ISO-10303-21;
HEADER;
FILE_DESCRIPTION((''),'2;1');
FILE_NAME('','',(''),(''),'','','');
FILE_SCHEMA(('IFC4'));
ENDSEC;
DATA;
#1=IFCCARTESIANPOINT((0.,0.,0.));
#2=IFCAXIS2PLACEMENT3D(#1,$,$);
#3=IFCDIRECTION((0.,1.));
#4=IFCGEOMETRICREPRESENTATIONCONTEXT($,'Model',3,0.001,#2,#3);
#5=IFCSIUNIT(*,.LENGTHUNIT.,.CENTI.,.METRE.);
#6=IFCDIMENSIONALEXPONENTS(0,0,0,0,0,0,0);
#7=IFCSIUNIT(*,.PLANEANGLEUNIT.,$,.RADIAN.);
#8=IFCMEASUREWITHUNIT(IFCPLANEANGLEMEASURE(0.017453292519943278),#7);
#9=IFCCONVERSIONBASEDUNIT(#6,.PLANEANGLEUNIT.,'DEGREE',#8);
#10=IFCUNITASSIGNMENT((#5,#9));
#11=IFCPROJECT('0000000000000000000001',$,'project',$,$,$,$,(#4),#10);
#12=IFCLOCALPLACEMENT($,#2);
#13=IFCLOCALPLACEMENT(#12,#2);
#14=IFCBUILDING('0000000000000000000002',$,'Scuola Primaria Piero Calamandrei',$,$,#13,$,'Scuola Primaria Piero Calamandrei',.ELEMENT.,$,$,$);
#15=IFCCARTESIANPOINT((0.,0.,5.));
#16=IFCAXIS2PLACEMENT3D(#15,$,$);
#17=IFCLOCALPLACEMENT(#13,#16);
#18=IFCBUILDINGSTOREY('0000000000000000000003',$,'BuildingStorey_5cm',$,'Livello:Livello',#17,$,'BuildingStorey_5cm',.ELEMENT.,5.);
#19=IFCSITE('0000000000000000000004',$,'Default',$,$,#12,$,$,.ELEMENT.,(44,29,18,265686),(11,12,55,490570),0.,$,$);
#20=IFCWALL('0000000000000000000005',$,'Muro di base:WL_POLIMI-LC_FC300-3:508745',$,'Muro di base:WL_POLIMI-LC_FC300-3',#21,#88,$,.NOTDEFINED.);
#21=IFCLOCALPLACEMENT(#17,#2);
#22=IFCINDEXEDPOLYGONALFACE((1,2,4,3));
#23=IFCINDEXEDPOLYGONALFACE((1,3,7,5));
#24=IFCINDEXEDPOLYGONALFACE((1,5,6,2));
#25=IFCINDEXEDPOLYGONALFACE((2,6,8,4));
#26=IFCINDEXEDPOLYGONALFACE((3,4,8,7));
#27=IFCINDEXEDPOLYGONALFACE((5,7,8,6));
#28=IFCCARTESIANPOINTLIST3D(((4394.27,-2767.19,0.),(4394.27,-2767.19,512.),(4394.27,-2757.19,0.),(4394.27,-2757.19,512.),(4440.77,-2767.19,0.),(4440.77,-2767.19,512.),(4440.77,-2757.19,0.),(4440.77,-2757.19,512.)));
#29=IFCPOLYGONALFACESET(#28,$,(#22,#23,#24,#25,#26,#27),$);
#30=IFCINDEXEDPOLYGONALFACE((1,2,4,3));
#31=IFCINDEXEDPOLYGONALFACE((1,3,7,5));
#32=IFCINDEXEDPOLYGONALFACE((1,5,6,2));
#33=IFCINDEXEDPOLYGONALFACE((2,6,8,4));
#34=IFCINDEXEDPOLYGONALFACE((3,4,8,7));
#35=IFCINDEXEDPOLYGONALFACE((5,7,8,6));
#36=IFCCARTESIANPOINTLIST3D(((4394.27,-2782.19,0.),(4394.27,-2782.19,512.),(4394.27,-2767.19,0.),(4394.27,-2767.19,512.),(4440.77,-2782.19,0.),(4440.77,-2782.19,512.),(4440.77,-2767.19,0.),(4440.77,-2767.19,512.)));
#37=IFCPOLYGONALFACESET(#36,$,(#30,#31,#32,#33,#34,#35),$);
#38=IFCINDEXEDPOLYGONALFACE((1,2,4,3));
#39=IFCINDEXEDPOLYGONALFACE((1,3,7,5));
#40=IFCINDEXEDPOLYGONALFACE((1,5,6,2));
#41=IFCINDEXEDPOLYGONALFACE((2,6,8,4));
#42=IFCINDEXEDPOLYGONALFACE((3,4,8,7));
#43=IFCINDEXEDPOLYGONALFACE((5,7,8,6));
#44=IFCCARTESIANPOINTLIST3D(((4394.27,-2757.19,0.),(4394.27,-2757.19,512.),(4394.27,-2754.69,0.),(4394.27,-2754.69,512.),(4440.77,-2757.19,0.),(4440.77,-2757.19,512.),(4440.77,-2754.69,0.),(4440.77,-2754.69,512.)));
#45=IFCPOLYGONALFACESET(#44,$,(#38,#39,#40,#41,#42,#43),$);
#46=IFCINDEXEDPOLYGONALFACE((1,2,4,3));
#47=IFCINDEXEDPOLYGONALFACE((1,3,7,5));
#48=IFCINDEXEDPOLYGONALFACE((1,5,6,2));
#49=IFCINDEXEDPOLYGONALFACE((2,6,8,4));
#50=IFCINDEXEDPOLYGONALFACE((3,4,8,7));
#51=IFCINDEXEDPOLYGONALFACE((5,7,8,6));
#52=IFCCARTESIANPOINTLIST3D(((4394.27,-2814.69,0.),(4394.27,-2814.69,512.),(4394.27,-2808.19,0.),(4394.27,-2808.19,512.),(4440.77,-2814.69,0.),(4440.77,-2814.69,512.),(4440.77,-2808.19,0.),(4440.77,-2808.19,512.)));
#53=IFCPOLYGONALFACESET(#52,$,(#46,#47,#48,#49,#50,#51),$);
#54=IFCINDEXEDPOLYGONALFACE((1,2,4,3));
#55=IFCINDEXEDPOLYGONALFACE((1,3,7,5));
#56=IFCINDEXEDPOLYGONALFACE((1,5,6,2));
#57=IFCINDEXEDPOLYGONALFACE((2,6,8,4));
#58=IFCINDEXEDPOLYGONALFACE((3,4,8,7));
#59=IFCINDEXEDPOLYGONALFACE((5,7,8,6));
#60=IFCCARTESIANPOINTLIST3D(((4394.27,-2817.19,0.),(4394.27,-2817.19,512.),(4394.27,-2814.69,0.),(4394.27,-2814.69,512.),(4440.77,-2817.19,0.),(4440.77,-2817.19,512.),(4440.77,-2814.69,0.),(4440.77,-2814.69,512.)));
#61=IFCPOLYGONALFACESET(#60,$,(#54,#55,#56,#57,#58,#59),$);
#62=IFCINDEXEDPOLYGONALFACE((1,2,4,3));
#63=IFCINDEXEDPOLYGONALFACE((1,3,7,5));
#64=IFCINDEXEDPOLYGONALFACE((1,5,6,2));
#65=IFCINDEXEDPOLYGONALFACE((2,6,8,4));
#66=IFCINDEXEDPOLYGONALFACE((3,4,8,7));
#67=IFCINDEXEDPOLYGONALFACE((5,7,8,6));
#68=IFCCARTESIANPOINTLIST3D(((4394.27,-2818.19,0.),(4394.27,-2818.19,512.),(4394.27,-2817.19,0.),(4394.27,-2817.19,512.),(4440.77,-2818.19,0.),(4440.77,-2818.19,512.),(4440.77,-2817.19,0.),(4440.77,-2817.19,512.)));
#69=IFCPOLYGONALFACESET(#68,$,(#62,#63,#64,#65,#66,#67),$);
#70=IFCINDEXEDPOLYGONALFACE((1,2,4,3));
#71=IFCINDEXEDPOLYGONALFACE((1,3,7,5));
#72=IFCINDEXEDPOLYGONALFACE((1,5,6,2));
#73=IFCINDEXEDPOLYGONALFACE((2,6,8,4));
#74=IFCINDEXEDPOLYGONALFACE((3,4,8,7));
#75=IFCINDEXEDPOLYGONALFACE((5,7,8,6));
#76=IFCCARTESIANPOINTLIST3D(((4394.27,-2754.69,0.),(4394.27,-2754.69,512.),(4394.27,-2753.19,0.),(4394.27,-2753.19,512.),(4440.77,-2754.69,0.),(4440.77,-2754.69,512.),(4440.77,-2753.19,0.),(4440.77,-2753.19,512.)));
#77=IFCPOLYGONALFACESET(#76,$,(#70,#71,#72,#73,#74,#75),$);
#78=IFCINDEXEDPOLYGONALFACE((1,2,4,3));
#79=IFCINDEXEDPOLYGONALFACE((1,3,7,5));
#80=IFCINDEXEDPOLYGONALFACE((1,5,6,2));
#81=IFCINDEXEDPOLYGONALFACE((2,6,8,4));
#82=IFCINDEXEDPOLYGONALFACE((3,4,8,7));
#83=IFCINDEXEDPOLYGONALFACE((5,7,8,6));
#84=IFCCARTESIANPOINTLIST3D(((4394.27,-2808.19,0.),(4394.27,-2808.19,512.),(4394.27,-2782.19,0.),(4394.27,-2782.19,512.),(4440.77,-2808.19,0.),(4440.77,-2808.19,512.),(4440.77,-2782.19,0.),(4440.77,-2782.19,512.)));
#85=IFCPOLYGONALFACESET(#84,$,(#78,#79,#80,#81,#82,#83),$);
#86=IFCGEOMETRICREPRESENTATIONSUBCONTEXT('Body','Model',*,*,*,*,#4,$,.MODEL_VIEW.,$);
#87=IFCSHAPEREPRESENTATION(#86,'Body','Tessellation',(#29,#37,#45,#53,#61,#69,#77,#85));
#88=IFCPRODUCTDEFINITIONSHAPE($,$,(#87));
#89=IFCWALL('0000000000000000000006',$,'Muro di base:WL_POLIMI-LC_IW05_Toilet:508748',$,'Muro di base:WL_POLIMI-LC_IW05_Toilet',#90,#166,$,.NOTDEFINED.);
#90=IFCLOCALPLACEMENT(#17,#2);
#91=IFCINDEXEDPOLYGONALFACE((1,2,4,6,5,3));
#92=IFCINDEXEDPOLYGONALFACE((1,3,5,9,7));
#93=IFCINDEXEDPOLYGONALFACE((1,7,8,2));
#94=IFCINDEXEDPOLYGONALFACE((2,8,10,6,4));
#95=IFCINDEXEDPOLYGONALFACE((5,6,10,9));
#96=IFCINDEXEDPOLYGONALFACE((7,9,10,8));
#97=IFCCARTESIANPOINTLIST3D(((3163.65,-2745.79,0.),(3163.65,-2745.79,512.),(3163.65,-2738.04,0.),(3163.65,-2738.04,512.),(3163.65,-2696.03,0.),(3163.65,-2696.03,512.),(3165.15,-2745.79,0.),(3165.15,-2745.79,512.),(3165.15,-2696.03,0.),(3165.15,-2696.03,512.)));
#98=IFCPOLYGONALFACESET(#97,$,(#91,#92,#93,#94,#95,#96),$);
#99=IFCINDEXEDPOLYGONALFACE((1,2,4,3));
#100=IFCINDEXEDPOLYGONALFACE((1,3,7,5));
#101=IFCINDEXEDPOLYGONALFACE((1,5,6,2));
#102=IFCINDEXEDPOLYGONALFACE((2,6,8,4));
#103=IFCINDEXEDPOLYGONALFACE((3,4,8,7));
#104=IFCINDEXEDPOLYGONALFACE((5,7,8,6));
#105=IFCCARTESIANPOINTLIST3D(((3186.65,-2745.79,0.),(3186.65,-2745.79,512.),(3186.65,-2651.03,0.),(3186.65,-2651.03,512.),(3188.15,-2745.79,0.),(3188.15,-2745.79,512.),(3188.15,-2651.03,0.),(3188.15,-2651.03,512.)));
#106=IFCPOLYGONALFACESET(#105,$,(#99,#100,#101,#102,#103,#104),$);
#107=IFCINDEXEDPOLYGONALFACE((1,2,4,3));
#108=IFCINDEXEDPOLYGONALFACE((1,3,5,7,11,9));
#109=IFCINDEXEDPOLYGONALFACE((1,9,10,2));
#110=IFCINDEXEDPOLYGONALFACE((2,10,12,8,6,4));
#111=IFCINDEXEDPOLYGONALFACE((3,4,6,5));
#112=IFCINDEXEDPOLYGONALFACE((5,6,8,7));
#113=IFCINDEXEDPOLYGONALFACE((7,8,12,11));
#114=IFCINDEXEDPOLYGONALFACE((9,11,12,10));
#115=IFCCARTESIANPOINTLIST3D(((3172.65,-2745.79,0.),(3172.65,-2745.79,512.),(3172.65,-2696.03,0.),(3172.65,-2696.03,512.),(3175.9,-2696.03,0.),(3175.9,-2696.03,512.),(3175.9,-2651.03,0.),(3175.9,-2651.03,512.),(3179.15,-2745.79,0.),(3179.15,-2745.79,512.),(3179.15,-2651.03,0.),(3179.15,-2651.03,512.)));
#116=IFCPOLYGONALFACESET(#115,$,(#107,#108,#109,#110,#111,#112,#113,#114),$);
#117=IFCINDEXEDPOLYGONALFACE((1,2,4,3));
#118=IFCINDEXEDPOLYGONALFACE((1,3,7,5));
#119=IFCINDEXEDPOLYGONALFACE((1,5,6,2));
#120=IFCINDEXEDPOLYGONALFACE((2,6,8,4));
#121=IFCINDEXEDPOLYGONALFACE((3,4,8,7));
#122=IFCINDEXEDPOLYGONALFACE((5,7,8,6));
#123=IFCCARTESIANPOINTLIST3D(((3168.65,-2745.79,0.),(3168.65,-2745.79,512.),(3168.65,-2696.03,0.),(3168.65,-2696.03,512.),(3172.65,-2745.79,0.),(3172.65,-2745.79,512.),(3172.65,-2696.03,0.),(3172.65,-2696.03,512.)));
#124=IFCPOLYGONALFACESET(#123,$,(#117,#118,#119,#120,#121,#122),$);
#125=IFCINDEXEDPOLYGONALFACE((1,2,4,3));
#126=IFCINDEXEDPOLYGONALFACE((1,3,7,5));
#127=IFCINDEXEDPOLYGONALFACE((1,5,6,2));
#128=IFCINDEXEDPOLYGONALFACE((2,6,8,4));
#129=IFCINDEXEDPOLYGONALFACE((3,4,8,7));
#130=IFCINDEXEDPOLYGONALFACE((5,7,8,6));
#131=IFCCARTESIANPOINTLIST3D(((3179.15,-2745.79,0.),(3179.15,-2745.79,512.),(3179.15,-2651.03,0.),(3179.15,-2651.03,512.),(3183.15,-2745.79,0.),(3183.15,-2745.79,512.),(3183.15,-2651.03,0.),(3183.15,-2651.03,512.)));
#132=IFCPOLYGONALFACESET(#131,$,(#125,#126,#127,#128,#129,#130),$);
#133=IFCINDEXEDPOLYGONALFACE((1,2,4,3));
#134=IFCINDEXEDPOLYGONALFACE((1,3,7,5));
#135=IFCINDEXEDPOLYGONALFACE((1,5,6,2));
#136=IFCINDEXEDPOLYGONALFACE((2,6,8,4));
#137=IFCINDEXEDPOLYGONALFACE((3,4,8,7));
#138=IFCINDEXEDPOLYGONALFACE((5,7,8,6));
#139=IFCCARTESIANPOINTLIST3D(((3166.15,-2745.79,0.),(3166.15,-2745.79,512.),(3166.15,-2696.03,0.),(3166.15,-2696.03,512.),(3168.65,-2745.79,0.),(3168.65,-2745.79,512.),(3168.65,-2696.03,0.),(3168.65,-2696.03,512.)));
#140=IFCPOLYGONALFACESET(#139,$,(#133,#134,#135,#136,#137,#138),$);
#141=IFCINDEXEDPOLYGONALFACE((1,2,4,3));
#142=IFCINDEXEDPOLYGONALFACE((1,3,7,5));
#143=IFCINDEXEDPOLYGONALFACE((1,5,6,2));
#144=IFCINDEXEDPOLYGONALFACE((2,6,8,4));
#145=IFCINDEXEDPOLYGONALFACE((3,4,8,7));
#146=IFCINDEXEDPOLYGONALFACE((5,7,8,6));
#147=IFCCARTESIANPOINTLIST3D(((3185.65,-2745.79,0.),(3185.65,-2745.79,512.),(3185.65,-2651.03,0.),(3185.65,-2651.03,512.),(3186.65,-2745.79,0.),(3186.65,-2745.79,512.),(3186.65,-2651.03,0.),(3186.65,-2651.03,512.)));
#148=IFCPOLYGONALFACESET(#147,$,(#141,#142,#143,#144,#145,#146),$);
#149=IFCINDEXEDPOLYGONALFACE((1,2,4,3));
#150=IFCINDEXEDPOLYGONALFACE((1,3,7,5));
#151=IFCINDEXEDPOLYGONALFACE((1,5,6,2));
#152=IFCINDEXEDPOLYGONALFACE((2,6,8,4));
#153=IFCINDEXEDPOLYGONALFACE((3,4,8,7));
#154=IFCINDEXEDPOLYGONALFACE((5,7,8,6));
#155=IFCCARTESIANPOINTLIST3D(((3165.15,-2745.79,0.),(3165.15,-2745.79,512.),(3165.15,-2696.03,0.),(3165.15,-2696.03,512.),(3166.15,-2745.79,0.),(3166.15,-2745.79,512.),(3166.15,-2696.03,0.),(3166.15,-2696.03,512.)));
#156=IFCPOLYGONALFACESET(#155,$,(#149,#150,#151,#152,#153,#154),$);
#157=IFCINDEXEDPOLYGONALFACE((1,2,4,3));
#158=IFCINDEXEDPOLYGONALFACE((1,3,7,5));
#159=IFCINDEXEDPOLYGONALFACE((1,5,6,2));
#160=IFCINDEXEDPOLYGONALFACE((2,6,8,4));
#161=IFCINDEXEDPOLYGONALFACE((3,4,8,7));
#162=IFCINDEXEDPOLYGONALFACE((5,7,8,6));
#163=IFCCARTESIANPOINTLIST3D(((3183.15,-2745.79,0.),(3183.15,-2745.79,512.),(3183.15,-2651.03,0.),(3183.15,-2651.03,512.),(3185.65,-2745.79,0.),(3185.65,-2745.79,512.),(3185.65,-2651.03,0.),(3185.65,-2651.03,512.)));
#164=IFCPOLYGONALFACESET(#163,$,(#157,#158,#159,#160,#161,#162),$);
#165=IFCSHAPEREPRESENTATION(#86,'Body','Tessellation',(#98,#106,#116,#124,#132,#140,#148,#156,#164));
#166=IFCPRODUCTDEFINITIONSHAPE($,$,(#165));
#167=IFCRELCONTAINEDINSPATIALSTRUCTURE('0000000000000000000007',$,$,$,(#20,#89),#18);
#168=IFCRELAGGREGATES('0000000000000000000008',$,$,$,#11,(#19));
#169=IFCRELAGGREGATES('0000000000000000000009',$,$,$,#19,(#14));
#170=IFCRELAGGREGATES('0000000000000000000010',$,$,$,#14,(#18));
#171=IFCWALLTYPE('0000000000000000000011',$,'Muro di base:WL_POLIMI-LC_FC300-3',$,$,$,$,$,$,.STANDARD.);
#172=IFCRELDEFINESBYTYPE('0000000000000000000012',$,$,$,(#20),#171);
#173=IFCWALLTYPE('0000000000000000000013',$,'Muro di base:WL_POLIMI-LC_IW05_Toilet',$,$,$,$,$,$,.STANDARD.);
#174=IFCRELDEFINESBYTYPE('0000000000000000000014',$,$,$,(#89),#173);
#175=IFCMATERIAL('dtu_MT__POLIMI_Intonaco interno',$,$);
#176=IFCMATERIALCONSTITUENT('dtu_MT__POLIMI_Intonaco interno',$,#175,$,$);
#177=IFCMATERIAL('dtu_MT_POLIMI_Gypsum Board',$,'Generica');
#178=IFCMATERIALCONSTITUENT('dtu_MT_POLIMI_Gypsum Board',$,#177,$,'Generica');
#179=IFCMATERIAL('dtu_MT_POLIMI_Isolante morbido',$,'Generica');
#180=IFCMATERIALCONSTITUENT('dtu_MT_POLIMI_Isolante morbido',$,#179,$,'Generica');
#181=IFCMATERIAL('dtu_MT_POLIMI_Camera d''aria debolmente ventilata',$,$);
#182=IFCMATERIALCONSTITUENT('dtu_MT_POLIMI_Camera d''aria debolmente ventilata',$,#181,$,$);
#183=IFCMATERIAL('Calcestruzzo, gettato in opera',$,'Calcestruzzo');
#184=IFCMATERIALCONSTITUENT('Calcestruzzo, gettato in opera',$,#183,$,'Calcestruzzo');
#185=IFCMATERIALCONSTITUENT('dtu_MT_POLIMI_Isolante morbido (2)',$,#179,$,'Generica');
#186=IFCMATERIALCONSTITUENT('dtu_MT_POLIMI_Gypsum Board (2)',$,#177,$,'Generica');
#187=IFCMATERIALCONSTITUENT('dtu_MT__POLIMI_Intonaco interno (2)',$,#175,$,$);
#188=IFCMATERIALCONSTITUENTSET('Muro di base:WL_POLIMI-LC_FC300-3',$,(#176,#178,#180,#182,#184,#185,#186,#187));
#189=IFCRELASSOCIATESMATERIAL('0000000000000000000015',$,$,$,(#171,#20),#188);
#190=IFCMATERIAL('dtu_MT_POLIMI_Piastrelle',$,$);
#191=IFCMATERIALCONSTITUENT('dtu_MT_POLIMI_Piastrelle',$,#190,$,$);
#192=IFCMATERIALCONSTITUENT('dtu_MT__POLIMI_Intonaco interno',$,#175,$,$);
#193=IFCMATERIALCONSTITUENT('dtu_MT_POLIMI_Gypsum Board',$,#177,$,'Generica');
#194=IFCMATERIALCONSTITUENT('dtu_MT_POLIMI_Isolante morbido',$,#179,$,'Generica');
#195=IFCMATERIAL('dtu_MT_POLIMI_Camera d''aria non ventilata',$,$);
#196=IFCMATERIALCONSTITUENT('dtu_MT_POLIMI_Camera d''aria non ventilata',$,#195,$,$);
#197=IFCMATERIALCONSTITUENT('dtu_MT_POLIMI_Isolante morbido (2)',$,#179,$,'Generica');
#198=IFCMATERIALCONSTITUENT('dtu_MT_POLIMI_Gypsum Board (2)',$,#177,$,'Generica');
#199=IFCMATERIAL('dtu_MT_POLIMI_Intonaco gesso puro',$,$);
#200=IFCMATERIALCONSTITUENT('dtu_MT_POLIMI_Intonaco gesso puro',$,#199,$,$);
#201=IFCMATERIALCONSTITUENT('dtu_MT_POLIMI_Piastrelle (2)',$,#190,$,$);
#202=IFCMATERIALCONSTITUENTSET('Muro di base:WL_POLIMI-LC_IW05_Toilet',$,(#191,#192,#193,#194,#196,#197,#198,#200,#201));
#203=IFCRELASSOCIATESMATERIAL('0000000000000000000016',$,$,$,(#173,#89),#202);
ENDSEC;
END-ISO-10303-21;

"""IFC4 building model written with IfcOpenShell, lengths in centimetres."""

from ifc_helpers import new_model, entity, si_unit, converted_unit, direction, frame, origin, place, context, subcontext, project, spatial, indexed_curve, outline, extrude, material, constituent, constituent_set, type_object, element, save


model = new_model("IFC4")

# Units and contexts
model_context = context("Model", 3, precision=0.001, world=origin(), true_north=direction((0.0, 1.0)))
body_context = subcontext(model_context, "Body", "Model", "MODEL_VIEW")
ifc_project = project(units=[si_unit("LENGTHUNIT", "METRE", prefix="CENTI"), converted_unit("PLANEANGLEUNIT", "DEGREE", entity("IfcPlaneAngleMeasure", 0.017453292519943278), si_unit("PLANEANGLEUNIT", "RADIAN"), dimensions=[0, 0, 0, 0, 0, 0, 0])], contexts=[model_context])

# Site, building, storey
site_placement = place(None, origin())
site = spatial("IfcSite", under=ifc_project, at=site_placement, Name="Default", CompositionType="ELEMENT", RefLatitude=(44, 29, 18, 265686), RefLongitude=(11, 12, 55, 490570), RefElevation=0.0)
building_placement = place(site_placement, origin())
building = spatial("IfcBuilding", under=site, at=building_placement, Name="Scuola Primaria Piero Calamandrei", LongName="Scuola Primaria Piero Calamandrei", CompositionType="ELEMENT")
storey_placement = place(building_placement, frame((0.0, 0.0, 5.0)))
storey = spatial("IfcBuildingStorey", under=building, at=storey_placement, Name="BuildingStorey_5cm", ObjectType="Livello:Livello", LongName="BuildingStorey_5cm", CompositionType="ELEMENT", Elevation=5.0)

# Shared definitions
ifc_material_1 = material(Name="dtu_MT_POLIMI_Intonaco gesso puro")

# Wall
ifc_material_2 = material(Name="dtu_MT_POLIMI_Camera d'aria debolmente ventilata")
ifc_material_3 = material(Name="dtu_MT_POLIMI_Isolante morbido", Category="Generica")
ifc_material_4 = material(Name="dtu_MT_POLIMI_Gypsum Board", Category="Generica")
ifc_material_5 = material(Name="dtu_MT__POLIMI_Intonaco interno")
ifc_constituent_1 = constituent(ifc_material_5, Name="dtu_MT__POLIMI_Intonaco interno")
ifc_constituent_2 = constituent(ifc_material_4, Name="dtu_MT_POLIMI_Gypsum Board", Category="Generica")
ifc_constituent_3 = constituent(ifc_material_3, Name="dtu_MT_POLIMI_Isolante morbido", Category="Generica")
ifc_constituent_4 = constituent(ifc_material_2, Name="dtu_MT_POLIMI_Camera d'aria debolmente ventilata")
ifc_material_6 = material(Name="Calcestruzzo, gettato in opera", Category="Calcestruzzo")
ifc_constituent_5 = constituent(ifc_material_6, Name="Calcestruzzo, gettato in opera", Category="Calcestruzzo")
ifc_constituent_6 = constituent(ifc_material_3, Name="dtu_MT_POLIMI_Isolante morbido (2)", Category="Generica")
ifc_constituent_7 = constituent(ifc_material_4, Name="dtu_MT_POLIMI_Gypsum Board (2)", Category="Generica")
ifc_constituent_8 = constituent(ifc_material_5, Name="dtu_MT__POLIMI_Intonaco interno (2)")
ifc_constituent_set_1 = constituent_set(constituents=[ifc_constituent_1, ifc_constituent_2, ifc_constituent_3, ifc_constituent_4, ifc_constituent_5, ifc_constituent_6, ifc_constituent_7, ifc_constituent_8], Name="Muro di base:WL_POLIMI-LC_FC300-3")
wall_type_1 = type_object("IfcWallType", Name="Muro di base:WL_POLIMI-LC_FC300-3", PredefinedType="STANDARD", material=ifc_constituent_set_1)
wall_1_placement = place(storey_placement, frame((4394.27, -2785.69, 0.0)))
element("IfcWall", 1, at=wall_1_placement, inside=storey, type_object=wall_type_1, material=ifc_constituent_set_1, Name="Muro di base:WL_POLIMI-LC_FC300-3:508745", ObjectType="Muro di base:WL_POLIMI-LC_FC300-3", PredefinedType="NOTDEFINED", context=body_context, shape_type="SweptSolid", body=[
    extrude(outline(indexed_curve([(-23.25, -5.0), (23.25, -5.0), (23.25, 5.0), (-23.25, 5.0), (-23.25, -5.0)], self_intersect=False)), frame((23.25, 23.5, 0.0)), (0.0, 0.0, 1.0), 512.0),
    extrude(outline(indexed_curve([(-23.25, -7.5), (23.25, -7.5), (23.25, 7.5), (-23.25, 7.5), (-23.25, -7.5)], self_intersect=False)), frame((23.25, 11.0, 0.0)), (0.0, 0.0, 1.0), 512.0),
    extrude(outline(indexed_curve([(-23.25, -1.25), (23.25, -1.25), (23.25, 1.25), (-23.25, 1.25), (-23.25, -1.25)], self_intersect=False)), frame((23.25, 29.75, 0.0)), (0.0, 0.0, 1.0), 512.0),
    extrude(outline(indexed_curve([(-23.25, -3.25), (23.25, -3.25), (23.25, 3.25), (-23.25, 3.25), (-23.25, -3.25)], self_intersect=False)), frame((23.25, -25.75, 0.0)), (0.0, 0.0, 1.0), 512.0),
    extrude(outline(indexed_curve([(-23.25, -1.25), (23.25, -1.25), (23.25, 1.25), (-23.25, 1.25), (-23.25, -1.25)], self_intersect=False)), frame((23.25, -30.25, 0.0)), (0.0, 0.0, 1.0), 512.0),
    extrude(outline(indexed_curve([(-0.5, -23.25), (0.5, -23.25), (0.5, 23.25), (-0.5, 23.25), (-0.5, -23.25)], self_intersect=False)), frame((23.25, -32.0, 0.0), z_axis=(0.0, 0.0, 1.0), x_axis=(0.0, 1.0, 0.0)), (0.0, 0.0, 1.0), 512.0),
    extrude(outline(indexed_curve([(-0.75, -23.25), (0.75, -23.25), (0.75, 23.25), (-0.75, 23.25), (-0.75, -23.25)], self_intersect=False)), frame((23.25, 31.75, 0.0), z_axis=(0.0, 0.0, 1.0), x_axis=(0.0, -1.0, 0.0)), (0.0, 0.0, 1.0), 512.0),
    extrude(outline(indexed_curve([(-23.25, -13.0), (23.25, -13.0), (23.25, 13.0), (-23.25, 13.0), (-23.25, -13.0)], self_intersect=False)), frame((23.25, -9.5, 0.0)), (0.0, 0.0, 1.0), 512.0),
])
ifc_material_7 = material(Name="dtu_MT_POLIMI_Camera d'aria non ventilata")

# Wall
ifc_material_8 = material(Name="dtu_MT_POLIMI_Piastrelle")
ifc_constituent_9 = constituent(ifc_material_8, Name="dtu_MT_POLIMI_Piastrelle")
ifc_constituent_10 = constituent(ifc_material_5, Name="dtu_MT__POLIMI_Intonaco interno")
ifc_constituent_11 = constituent(ifc_material_4, Name="dtu_MT_POLIMI_Gypsum Board", Category="Generica")
ifc_constituent_12 = constituent(ifc_material_3, Name="dtu_MT_POLIMI_Isolante morbido", Category="Generica")
ifc_constituent_13 = constituent(ifc_material_7, Name="dtu_MT_POLIMI_Camera d'aria non ventilata")
ifc_constituent_14 = constituent(ifc_material_3, Name="dtu_MT_POLIMI_Isolante morbido (2)", Category="Generica")
ifc_constituent_15 = constituent(ifc_material_4, Name="dtu_MT_POLIMI_Gypsum Board (2)", Category="Generica")
ifc_constituent_16 = constituent(ifc_material_1, Name="dtu_MT_POLIMI_Intonaco gesso puro")
ifc_constituent_17 = constituent(ifc_material_8, Name="dtu_MT_POLIMI_Piastrelle (2)")
ifc_constituent_set_2 = constituent_set(constituents=[ifc_constituent_9, ifc_constituent_10, ifc_constituent_11, ifc_constituent_12, ifc_constituent_13, ifc_constituent_14, ifc_constituent_15, ifc_constituent_16, ifc_constituent_17], Name="Muro di base:WL_POLIMI-LC_IW05_Toilet")
wall_type_2 = type_object("IfcWallType", Name="Muro di base:WL_POLIMI-LC_IW05_Toilet", PredefinedType="STANDARD", material=ifc_constituent_set_2)
wall_2_placement = place(storey_placement, frame((3175.9, -2745.79, 0.0), z_axis=(0.0, 0.0, 1.0), x_axis=(0.0, 1.0, 0.0)))
element("IfcWall", 2, at=wall_2_placement, inside=storey, type_object=wall_type_2, material=ifc_constituent_set_2, Name="Muro di base:WL_POLIMI-LC_IW05_Toilet:508748", ObjectType="Muro di base:WL_POLIMI-LC_IW05_Toilet", PredefinedType="NOTDEFINED", context=body_context, shape_type="SweptSolid", body=[
    extrude(outline(indexed_curve([(13.7, -0.6), (21.45, -0.6), (21.45, 0.9), (-28.3, 0.9), (-28.3, -0.6), (13.7, -0.6)], self_intersect=False)), frame((21.45, 11.65, 0.0), z_axis=(0.0, 0.0, 1.0), x_axis=(-1.0, 0.0, 0.0)), (0.0, 0.0, 1.0), 512.0),
    extrude(outline(indexed_curve([(-0.75, -47.38), (0.75, -47.38), (0.75, 47.38), (-0.75, 47.38), (-0.75, -47.38)], self_intersect=False)), frame((47.38, -11.5, 0.0), z_axis=(0.0, 0.0, 1.0), x_axis=(0.0, 1.0, 0.0)), (0.0, 0.0, 1.0), 512.0),
    extrude(outline(indexed_curve([(0.0, -1.59), (3.25, -1.59), (3.25, 48.17), (-3.25, 48.17), (-3.25, -46.59), (0.0, -46.59), (0.0, -1.59)], self_intersect=False)), frame((48.17, 0.0, 0.0), z_axis=(0.0, 0.0, 1.0), x_axis=(0.0, 1.0, 0.0)), (0.0, 0.0, 1.0), 512.0),
    extrude(outline(indexed_curve([(-24.88, -2.0), (24.88, -2.0), (24.88, 2.0), (-24.88, 2.0), (-24.88, -2.0)], self_intersect=False)), frame((24.88, 5.25, 0.0)), (0.0, 0.0, 1.0), 512.0),
    extrude(outline(indexed_curve([(-47.38, -2.0), (47.38, -2.0), (47.38, 2.0), (-47.38, 2.0), (-47.38, -2.0)], self_intersect=False)), frame((47.38, -5.25, 0.0)), (0.0, 0.0, 1.0), 512.0),
    extrude(outline(indexed_curve([(-24.88, -1.25), (24.88, -1.25), (24.88, 1.25), (-24.88, 1.25), (-24.88, -1.25)], self_intersect=False)), frame((24.88, 8.5, 0.0)), (0.0, 0.0, 1.0), 512.0),
    extrude(outline(indexed_curve([(-47.38, -0.5), (47.38, -0.5), (47.38, 0.5), (-47.38, 0.5), (-47.38, -0.5)], self_intersect=False)), frame((47.38, -10.25, 0.0)), (0.0, 0.0, 1.0), 512.0),
    extrude(outline(indexed_curve([(-24.88, -0.5), (24.88, -0.5), (24.88, 0.5), (-24.88, 0.5), (-24.88, -0.5)], self_intersect=False)), frame((24.88, 10.25, 0.0)), (0.0, 0.0, 1.0), 512.0),
    extrude(outline(indexed_curve([(-47.38, -1.25), (47.38, -1.25), (47.38, 1.25), (-47.38, 1.25), (-47.38, -1.25)], self_intersect=False)), frame((47.38, -8.5, 0.0)), (0.0, 0.0, 1.0), 512.0),
])

save(model, "model.ifc")
